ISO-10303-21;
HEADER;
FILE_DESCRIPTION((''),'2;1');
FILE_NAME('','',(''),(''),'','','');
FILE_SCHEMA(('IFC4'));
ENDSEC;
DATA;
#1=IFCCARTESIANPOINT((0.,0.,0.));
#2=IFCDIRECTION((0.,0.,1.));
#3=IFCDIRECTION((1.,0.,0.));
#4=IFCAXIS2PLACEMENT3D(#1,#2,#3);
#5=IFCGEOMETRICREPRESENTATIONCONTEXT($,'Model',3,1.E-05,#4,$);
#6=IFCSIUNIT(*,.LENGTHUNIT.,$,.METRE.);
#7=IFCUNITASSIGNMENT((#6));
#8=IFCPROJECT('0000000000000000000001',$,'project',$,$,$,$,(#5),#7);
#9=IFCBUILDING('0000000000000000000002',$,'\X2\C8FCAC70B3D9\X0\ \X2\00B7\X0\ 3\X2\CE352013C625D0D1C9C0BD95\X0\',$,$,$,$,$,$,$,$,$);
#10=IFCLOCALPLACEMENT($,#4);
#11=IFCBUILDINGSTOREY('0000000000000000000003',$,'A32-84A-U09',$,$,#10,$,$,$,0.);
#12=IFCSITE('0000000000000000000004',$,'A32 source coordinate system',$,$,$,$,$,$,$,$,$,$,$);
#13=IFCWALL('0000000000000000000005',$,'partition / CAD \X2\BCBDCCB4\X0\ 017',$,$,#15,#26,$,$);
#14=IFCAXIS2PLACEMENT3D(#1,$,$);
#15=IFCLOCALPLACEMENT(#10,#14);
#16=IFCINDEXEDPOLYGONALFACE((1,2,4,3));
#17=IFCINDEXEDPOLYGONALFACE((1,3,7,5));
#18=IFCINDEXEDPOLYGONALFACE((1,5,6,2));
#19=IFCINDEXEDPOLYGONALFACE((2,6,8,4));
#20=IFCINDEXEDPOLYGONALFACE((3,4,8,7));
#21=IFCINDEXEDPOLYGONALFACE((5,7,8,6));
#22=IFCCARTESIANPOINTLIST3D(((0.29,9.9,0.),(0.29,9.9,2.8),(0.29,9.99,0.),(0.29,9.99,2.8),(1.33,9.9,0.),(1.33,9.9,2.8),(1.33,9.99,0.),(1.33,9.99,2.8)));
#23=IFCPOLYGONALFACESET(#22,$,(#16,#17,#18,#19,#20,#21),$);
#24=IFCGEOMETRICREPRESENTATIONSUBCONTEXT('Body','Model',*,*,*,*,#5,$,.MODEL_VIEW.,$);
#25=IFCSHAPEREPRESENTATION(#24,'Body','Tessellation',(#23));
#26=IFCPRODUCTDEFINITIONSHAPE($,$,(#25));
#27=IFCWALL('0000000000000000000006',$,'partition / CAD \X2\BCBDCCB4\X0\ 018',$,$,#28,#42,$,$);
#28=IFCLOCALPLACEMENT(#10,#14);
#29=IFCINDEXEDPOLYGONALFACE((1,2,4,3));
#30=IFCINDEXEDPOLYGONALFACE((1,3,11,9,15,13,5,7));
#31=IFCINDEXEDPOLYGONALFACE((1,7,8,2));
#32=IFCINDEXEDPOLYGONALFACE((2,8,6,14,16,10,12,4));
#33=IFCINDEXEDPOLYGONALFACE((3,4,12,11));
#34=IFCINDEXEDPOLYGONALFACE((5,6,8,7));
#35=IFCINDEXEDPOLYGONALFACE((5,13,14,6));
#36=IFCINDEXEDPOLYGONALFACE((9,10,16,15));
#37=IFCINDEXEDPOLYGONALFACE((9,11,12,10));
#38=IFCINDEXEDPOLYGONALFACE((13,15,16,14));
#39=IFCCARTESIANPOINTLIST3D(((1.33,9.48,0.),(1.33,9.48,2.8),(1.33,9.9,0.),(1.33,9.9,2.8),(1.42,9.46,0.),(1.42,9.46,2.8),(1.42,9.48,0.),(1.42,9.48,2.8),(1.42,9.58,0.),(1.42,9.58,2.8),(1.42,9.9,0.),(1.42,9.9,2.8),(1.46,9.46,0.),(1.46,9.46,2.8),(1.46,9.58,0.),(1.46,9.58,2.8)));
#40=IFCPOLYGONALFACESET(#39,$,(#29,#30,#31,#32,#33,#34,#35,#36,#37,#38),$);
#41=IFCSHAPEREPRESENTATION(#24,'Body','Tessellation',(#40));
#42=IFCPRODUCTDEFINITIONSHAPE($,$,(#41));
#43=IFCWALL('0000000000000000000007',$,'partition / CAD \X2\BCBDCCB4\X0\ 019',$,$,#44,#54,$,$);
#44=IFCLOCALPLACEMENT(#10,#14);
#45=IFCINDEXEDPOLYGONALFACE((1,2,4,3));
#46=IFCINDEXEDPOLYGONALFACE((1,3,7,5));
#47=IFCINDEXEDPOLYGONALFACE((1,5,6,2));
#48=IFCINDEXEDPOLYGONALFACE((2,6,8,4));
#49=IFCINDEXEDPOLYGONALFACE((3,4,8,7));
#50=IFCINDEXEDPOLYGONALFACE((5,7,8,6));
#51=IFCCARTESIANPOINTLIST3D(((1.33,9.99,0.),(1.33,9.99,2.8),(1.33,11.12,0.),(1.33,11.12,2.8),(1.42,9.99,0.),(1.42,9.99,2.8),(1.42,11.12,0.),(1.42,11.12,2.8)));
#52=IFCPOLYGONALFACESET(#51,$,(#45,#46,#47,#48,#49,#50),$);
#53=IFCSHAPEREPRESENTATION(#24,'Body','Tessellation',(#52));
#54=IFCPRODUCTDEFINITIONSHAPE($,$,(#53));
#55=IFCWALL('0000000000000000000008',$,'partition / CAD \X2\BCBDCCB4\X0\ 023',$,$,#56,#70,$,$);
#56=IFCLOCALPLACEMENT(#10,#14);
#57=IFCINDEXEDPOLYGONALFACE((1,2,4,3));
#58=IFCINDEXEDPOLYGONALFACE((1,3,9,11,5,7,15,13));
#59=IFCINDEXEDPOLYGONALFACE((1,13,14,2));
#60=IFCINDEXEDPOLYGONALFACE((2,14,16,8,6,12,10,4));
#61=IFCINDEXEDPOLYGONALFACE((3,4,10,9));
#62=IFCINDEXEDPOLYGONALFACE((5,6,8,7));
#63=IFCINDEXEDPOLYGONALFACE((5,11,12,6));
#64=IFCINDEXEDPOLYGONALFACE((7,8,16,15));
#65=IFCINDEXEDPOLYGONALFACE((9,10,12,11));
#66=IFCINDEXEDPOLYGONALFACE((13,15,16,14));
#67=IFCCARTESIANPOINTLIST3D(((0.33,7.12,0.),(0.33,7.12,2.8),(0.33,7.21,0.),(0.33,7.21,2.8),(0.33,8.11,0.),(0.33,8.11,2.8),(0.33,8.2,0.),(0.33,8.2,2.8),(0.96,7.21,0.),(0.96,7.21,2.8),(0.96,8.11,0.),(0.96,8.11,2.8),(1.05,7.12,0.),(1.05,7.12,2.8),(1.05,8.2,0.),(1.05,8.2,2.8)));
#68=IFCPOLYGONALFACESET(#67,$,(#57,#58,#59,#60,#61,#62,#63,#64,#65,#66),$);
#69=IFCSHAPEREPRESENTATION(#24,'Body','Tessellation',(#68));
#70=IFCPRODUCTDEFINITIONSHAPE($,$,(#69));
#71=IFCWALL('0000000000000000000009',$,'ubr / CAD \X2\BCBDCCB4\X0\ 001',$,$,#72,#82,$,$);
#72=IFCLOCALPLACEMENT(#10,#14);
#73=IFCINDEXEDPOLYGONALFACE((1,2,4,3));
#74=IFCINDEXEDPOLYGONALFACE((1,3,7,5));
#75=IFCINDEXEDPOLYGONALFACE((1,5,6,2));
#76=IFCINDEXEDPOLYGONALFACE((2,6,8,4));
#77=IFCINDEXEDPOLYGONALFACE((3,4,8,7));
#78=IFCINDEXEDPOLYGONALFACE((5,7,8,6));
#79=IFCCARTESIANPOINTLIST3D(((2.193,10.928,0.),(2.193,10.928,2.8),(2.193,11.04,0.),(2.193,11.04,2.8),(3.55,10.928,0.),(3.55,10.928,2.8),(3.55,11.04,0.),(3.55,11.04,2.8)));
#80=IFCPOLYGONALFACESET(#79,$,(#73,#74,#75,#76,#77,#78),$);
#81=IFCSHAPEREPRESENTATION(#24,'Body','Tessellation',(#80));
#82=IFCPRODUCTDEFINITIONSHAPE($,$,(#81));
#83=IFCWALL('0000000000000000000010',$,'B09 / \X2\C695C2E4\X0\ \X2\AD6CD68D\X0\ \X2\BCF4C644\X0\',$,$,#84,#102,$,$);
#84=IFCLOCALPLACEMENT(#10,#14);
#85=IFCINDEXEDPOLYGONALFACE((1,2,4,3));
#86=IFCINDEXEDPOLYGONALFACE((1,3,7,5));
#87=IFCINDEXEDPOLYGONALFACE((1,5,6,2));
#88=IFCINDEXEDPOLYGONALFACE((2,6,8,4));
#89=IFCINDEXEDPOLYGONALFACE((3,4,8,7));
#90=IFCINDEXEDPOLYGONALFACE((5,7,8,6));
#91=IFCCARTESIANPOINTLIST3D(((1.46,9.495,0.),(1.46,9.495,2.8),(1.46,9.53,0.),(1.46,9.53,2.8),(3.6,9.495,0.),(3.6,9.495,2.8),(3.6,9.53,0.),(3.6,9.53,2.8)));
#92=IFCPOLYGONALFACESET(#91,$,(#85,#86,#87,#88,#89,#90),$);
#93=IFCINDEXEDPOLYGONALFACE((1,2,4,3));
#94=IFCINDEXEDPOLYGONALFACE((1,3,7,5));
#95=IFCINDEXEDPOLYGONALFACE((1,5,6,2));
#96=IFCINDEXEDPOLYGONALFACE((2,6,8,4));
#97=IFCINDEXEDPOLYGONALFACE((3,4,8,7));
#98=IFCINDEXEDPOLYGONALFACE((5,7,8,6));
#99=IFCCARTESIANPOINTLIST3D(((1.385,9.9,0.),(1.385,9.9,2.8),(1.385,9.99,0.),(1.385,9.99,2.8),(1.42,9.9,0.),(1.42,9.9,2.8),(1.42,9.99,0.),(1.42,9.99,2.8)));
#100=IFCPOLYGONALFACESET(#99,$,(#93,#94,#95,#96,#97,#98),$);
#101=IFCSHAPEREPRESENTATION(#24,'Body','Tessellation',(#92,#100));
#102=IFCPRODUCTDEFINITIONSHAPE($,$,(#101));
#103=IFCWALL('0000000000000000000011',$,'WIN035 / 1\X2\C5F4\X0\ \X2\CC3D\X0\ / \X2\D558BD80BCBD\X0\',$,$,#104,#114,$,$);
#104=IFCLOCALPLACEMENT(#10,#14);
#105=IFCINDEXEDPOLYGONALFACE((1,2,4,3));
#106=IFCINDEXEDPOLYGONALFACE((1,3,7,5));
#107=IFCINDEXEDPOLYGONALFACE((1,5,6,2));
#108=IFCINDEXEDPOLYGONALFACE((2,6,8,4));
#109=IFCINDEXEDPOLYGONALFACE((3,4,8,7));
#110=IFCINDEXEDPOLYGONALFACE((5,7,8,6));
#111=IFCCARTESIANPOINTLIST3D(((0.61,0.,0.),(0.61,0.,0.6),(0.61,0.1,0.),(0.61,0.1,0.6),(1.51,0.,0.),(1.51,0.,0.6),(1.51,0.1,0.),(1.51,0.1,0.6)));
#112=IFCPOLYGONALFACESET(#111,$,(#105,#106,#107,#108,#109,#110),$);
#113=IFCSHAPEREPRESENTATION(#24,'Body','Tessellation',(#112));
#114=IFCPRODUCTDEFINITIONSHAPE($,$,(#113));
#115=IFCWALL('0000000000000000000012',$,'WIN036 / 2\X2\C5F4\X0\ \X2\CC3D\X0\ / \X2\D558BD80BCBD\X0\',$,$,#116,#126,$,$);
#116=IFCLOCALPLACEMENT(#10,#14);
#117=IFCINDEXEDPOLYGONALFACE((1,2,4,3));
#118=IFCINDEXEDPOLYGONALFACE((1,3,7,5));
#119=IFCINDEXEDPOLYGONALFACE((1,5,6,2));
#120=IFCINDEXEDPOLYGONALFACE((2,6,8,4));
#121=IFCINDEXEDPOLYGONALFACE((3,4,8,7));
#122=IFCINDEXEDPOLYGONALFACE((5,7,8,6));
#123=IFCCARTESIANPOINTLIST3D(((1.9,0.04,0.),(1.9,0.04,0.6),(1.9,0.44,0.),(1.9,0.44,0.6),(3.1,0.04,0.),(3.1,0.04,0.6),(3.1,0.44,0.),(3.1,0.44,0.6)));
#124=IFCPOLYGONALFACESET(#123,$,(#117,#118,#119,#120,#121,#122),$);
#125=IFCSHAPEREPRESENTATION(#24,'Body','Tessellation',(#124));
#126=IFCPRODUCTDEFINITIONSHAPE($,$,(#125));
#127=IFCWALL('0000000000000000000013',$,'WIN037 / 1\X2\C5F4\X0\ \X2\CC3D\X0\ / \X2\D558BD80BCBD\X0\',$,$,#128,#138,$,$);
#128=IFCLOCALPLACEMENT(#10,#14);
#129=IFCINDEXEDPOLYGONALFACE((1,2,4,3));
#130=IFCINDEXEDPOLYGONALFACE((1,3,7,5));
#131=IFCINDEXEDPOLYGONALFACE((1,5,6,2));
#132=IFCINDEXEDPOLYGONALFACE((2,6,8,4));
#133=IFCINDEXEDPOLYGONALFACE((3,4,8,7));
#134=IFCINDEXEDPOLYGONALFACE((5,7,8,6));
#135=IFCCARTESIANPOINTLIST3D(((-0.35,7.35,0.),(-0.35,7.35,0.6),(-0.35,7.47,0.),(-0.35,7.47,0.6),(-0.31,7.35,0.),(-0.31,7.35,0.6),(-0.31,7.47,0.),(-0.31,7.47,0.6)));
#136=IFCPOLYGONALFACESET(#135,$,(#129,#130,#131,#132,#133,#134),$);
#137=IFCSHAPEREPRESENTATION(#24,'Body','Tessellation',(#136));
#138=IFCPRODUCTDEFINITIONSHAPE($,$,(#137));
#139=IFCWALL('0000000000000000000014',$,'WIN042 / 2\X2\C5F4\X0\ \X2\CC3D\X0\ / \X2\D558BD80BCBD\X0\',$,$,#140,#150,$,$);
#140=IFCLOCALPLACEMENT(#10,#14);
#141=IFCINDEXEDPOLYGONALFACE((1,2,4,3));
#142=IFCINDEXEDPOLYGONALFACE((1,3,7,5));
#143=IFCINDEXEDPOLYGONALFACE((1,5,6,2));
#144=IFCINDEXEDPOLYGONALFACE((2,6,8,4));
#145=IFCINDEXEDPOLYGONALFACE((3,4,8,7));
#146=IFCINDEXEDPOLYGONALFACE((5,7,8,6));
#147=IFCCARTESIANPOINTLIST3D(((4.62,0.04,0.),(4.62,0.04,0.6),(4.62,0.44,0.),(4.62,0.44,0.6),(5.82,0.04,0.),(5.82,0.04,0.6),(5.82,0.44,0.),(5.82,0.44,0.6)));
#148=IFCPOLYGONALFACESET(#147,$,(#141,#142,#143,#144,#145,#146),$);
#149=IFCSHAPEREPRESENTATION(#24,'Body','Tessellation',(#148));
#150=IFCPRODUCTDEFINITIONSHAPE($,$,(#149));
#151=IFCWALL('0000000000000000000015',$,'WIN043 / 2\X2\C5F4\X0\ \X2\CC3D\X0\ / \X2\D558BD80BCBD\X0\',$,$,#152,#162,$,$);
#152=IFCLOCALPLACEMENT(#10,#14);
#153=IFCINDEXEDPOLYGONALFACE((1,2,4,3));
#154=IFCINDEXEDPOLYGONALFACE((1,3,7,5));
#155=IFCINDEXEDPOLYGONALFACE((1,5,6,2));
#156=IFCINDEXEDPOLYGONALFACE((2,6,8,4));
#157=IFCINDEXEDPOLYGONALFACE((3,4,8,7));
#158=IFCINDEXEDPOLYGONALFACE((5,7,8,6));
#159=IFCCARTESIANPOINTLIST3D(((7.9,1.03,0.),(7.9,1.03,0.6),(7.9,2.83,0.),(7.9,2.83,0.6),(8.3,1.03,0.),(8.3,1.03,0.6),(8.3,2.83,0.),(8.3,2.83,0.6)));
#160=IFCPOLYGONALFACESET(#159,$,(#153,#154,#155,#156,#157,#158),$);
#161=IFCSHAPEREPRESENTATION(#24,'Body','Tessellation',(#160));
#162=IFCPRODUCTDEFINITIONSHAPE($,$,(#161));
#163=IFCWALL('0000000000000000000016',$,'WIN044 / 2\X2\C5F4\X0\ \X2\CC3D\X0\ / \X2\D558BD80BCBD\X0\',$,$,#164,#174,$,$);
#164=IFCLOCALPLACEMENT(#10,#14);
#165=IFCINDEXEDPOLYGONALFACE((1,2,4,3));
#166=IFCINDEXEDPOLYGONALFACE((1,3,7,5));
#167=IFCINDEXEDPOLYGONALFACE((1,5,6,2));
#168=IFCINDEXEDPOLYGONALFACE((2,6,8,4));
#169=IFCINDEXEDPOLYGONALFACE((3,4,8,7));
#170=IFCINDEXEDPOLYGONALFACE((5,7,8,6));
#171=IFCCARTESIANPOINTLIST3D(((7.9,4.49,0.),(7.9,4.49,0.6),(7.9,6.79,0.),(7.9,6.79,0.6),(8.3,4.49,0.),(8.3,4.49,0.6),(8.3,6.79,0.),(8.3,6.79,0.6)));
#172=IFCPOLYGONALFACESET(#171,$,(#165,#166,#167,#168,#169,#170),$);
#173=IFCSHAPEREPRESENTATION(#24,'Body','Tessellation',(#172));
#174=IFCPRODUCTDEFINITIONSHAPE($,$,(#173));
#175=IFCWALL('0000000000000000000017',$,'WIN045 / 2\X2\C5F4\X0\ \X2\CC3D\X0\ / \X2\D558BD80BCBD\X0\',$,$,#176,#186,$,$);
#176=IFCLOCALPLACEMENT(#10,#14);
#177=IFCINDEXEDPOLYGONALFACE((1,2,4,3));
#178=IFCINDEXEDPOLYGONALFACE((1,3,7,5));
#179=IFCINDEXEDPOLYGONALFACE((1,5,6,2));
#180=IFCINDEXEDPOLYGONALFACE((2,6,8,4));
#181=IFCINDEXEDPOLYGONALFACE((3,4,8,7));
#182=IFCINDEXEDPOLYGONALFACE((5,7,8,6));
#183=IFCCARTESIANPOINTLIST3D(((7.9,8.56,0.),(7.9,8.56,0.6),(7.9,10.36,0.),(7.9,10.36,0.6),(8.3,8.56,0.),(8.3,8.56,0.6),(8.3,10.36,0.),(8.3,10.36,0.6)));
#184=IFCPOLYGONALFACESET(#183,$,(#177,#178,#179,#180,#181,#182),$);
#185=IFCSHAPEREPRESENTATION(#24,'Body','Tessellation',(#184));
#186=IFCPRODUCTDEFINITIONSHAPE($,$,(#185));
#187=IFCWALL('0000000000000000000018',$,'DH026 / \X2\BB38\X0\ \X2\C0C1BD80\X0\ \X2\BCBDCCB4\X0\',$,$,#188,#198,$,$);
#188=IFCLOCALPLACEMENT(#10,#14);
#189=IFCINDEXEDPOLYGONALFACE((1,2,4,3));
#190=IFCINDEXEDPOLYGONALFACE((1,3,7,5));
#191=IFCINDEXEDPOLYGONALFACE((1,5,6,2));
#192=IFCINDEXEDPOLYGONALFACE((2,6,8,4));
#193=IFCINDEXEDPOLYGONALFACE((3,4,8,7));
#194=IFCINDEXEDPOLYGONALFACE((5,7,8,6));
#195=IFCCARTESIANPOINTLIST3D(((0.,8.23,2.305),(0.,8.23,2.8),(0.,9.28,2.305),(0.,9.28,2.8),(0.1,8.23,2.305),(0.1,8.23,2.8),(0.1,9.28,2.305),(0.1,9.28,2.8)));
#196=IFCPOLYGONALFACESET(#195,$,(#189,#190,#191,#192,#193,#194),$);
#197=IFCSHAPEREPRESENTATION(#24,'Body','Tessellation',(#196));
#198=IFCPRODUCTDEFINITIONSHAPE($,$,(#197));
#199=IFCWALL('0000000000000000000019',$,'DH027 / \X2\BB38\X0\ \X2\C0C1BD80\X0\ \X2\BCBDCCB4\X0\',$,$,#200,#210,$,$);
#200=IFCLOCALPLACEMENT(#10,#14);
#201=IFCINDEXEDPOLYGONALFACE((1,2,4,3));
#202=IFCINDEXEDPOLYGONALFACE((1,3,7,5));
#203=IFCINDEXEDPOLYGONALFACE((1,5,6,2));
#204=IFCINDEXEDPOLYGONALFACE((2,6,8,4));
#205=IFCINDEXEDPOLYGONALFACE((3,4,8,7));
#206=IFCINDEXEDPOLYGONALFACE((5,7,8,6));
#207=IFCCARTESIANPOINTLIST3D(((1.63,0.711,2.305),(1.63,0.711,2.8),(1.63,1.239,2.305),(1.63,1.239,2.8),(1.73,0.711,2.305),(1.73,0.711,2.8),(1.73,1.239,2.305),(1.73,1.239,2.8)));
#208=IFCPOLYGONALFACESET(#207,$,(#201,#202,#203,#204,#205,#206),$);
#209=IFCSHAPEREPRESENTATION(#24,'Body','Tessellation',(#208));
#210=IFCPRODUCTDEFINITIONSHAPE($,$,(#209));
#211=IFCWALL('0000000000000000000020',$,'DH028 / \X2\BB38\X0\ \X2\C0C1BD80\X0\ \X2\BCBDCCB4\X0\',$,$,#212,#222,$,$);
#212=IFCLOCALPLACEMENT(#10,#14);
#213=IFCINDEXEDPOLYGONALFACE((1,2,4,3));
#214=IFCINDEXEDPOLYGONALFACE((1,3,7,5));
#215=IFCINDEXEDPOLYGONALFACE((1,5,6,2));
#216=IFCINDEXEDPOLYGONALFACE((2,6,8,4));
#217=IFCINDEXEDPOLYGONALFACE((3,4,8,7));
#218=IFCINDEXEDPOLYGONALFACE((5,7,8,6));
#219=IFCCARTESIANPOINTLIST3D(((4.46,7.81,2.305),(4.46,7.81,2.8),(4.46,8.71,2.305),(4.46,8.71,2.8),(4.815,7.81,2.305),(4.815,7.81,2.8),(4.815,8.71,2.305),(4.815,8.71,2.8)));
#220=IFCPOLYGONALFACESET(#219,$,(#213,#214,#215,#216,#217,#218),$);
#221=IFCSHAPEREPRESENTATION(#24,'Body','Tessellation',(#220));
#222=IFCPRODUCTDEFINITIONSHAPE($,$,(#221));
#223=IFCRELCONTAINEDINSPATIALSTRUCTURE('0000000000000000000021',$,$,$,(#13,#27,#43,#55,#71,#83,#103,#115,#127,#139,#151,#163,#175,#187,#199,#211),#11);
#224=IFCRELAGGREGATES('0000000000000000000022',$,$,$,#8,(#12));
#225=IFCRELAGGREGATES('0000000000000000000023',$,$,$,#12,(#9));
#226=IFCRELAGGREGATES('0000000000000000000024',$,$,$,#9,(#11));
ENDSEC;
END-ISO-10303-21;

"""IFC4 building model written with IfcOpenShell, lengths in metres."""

from ifc_helpers import new_model, si_unit, frame, origin, origin_with_axes, place, context, subcontext, project, spatial, polyline, outline, extrude, element, save


model = new_model("IFC4")

# Units and contexts
model_context = context("Model", 3, precision=1e-05, world=origin_with_axes())
body_context = subcontext(model_context, "Body", "Model", "MODEL_VIEW")
ifc_project = project(units=[si_unit("LENGTHUNIT", "METRE")], contexts=[model_context])

# Site, building, storey
site = spatial("IfcSite", under=ifc_project, Name="A32 source coordinate system")
building = spatial("IfcBuilding", under=site, Name="주거동 · 3층–옥탑지붕")
storey_placement = place(None, origin_with_axes())
storey = spatial("IfcBuildingStorey", under=building, at=storey_placement, Name="A32-84A-U09", Elevation=0.0)

# Walls
wall_1_placement = place(storey_placement, origin_with_axes())
element("IfcWall", 1, at=wall_1_placement, inside=storey, Name="partition / CAD 벽체 017", context=body_context, shape_type="SweptSolid", body=[
    extrude(outline(polyline([(1.33, 9.99), (1.33, 9.9), (0.29, 9.9), (0.29, 9.99), (1.33, 9.99)])), origin(), (0.0, 0.0, 1.0), 2.8),
])
wall_2_placement = place(storey_placement, origin_with_axes())
element("IfcWall", 2, at=wall_2_placement, inside=storey, Name="partition / CAD 벽체 018", context=body_context, shape_type="SweptSolid", body=[
    extrude(outline(polyline([(1.42, 9.58), (1.46, 9.58), (1.46, 9.46), (1.42, 9.46), (1.42, 9.48), (1.33, 9.48), (1.33, 9.9), (1.42, 9.9), (1.42, 9.58)])), origin(), (0.0, 0.0, 1.0), 2.8),
])
wall_3_placement = place(storey_placement, origin_with_axes())
element("IfcWall", 3, at=wall_3_placement, inside=storey, Name="partition / CAD 벽체 019", context=body_context, shape_type="SweptSolid", body=[
    extrude(outline(polyline([(1.33, 11.12), (1.42, 11.12), (1.42, 9.99), (1.33, 9.99), (1.33, 11.12)])), origin(), (0.0, 0.0, 1.0), 2.8),
])
wall_4_placement = place(storey_placement, origin_with_axes())
element("IfcWall", 4, at=wall_4_placement, inside=storey, Name="partition / CAD 벽체 023", context=body_context, shape_type="SweptSolid", body=[
    extrude(outline(polyline([(0.96, 8.11), (0.33, 8.11), (0.33, 8.2), (1.05, 8.2), (1.05, 7.12), (0.33, 7.12), (0.33, 7.21), (0.96, 7.21), (0.96, 8.11)])), origin(), (0.0, 0.0, 1.0), 2.8),
])
wall_5_placement = place(storey_placement, origin_with_axes())
element("IfcWall", 5, at=wall_5_placement, inside=storey, Name="ubr / CAD 벽체 001", context=body_context, shape_type="SweptSolid", body=[
    extrude(outline(polyline([(3.55, 11.04), (3.55, 10.928), (2.193, 10.928), (2.193, 11.04), (3.55, 11.04)])), origin(), (0.0, 0.0, 1.0), 2.8),
])
wall_6_placement = place(storey_placement, origin_with_axes())
element("IfcWall", 6, at=wall_6_placement, inside=storey, Name="B09 / 욕실 구획 보완", context=body_context, shape_type="SweptSolid", body=[
    extrude(outline(polyline([(3.6, 9.53), (3.6, 9.495), (1.46, 9.495), (1.46, 9.53), (3.6, 9.53)])), origin(), (0.0, 0.0, 1.0), 2.8),
    extrude(outline(polyline([(1.42, 9.9), (1.385, 9.9), (1.385, 9.99), (1.42, 9.99), (1.42, 9.9)])), origin(), (0.0, 0.0, 1.0), 2.8),
])
wall_7_placement = place(storey_placement, origin_with_axes())
element("IfcWall", 7, at=wall_7_placement, inside=storey, Name="WIN035 / 1열 창 / 하부벽", context=body_context, shape_type="SweptSolid", body=[
    extrude(outline(polyline([(0.61, 0.1), (1.51, 0.1), (1.51, 0.0), (0.61, 0.0), (0.61, 0.1)])), origin(), (0.0, 0.0, 1.0), 0.6),
])
wall_8_placement = place(storey_placement, origin_with_axes())
element("IfcWall", 8, at=wall_8_placement, inside=storey, Name="WIN036 / 2열 창 / 하부벽", context=body_context, shape_type="SweptSolid", body=[
    extrude(outline(polyline([(1.9, 0.44), (3.1, 0.44), (3.1, 0.04), (1.9, 0.04), (1.9, 0.44)])), origin(), (0.0, 0.0, 1.0), 0.6),
])
wall_9_placement = place(storey_placement, origin_with_axes())
element("IfcWall", 9, at=wall_9_placement, inside=storey, Name="WIN037 / 1열 창 / 하부벽", context=body_context, shape_type="SweptSolid", body=[
    extrude(outline(polyline([(-0.31, 7.47), (-0.31, 7.35), (-0.35, 7.35), (-0.35, 7.47), (-0.31, 7.47)])), origin(), (0.0, 0.0, 1.0), 0.6),
])
wall_10_placement = place(storey_placement, origin_with_axes())
element("IfcWall", 10, at=wall_10_placement, inside=storey, Name="WIN042 / 2열 창 / 하부벽", context=body_context, shape_type="SweptSolid", body=[
    extrude(outline(polyline([(4.62, 0.44), (5.82, 0.44), (5.82, 0.04), (4.62, 0.04), (4.62, 0.44)])), origin(), (0.0, 0.0, 1.0), 0.6),
])
wall_11_placement = place(storey_placement, origin_with_axes())
element("IfcWall", 11, at=wall_11_placement, inside=storey, Name="WIN043 / 2열 창 / 하부벽", context=body_context, shape_type="SweptSolid", body=[
    extrude(outline(polyline([(7.9, 2.83), (8.3, 2.83), (8.3, 1.03), (7.9, 1.03), (7.9, 2.83)])), origin(), (0.0, 0.0, 1.0), 0.6),
])
wall_12_placement = place(storey_placement, origin_with_axes())
element("IfcWall", 12, at=wall_12_placement, inside=storey, Name="WIN044 / 2열 창 / 하부벽", context=body_context, shape_type="SweptSolid", body=[
    extrude(outline(polyline([(7.9, 6.79), (8.3, 6.79), (8.3, 4.49), (7.9, 4.49), (7.9, 6.79)])), origin(), (0.0, 0.0, 1.0), 0.6),
])
wall_13_placement = place(storey_placement, origin_with_axes())
element("IfcWall", 13, at=wall_13_placement, inside=storey, Name="WIN045 / 2열 창 / 하부벽", context=body_context, shape_type="SweptSolid", body=[
    extrude(outline(polyline([(7.9, 10.36), (8.3, 10.36), (8.3, 8.56), (7.9, 8.56), (7.9, 10.36)])), origin(), (0.0, 0.0, 1.0), 0.6),
])
wall_14_placement = place(storey_placement, origin_with_axes())
element("IfcWall", 14, at=wall_14_placement, inside=storey, Name="DH026 / 문 상부 벽체", context=body_context, shape_type="SweptSolid", body=[
    extrude(outline(polyline([(0.1, 9.28), (0.1, 8.23), (0.0, 8.23), (0.0, 9.28), (0.1, 9.28)])), frame((0.0, 0.0, 2.305)), (0.0, 0.0, 1.0), 0.495),
])
wall_15_placement = place(storey_placement, origin_with_axes())
element("IfcWall", 15, at=wall_15_placement, inside=storey, Name="DH027 / 문 상부 벽체", context=body_context, shape_type="SweptSolid", body=[
    extrude(outline(polyline([(1.63, 1.239), (1.73, 1.239), (1.73, 0.711), (1.63, 0.711), (1.63, 1.239)])), frame((0.0, 0.0, 2.305)), (0.0, 0.0, 1.0), 0.495),
])
wall_16_placement = place(storey_placement, origin_with_axes())
element("IfcWall", 16, at=wall_16_placement, inside=storey, Name="DH028 / 문 상부 벽체", context=body_context, shape_type="SweptSolid", body=[
    extrude(outline(polyline([(4.815, 8.71), (4.815, 7.81), (4.46, 7.81), (4.46, 8.71), (4.815, 8.71)])), frame((0.0, 0.0, 2.305)), (0.0, 0.0, 1.0), 0.495),
])

save(model, "model.ifc")
